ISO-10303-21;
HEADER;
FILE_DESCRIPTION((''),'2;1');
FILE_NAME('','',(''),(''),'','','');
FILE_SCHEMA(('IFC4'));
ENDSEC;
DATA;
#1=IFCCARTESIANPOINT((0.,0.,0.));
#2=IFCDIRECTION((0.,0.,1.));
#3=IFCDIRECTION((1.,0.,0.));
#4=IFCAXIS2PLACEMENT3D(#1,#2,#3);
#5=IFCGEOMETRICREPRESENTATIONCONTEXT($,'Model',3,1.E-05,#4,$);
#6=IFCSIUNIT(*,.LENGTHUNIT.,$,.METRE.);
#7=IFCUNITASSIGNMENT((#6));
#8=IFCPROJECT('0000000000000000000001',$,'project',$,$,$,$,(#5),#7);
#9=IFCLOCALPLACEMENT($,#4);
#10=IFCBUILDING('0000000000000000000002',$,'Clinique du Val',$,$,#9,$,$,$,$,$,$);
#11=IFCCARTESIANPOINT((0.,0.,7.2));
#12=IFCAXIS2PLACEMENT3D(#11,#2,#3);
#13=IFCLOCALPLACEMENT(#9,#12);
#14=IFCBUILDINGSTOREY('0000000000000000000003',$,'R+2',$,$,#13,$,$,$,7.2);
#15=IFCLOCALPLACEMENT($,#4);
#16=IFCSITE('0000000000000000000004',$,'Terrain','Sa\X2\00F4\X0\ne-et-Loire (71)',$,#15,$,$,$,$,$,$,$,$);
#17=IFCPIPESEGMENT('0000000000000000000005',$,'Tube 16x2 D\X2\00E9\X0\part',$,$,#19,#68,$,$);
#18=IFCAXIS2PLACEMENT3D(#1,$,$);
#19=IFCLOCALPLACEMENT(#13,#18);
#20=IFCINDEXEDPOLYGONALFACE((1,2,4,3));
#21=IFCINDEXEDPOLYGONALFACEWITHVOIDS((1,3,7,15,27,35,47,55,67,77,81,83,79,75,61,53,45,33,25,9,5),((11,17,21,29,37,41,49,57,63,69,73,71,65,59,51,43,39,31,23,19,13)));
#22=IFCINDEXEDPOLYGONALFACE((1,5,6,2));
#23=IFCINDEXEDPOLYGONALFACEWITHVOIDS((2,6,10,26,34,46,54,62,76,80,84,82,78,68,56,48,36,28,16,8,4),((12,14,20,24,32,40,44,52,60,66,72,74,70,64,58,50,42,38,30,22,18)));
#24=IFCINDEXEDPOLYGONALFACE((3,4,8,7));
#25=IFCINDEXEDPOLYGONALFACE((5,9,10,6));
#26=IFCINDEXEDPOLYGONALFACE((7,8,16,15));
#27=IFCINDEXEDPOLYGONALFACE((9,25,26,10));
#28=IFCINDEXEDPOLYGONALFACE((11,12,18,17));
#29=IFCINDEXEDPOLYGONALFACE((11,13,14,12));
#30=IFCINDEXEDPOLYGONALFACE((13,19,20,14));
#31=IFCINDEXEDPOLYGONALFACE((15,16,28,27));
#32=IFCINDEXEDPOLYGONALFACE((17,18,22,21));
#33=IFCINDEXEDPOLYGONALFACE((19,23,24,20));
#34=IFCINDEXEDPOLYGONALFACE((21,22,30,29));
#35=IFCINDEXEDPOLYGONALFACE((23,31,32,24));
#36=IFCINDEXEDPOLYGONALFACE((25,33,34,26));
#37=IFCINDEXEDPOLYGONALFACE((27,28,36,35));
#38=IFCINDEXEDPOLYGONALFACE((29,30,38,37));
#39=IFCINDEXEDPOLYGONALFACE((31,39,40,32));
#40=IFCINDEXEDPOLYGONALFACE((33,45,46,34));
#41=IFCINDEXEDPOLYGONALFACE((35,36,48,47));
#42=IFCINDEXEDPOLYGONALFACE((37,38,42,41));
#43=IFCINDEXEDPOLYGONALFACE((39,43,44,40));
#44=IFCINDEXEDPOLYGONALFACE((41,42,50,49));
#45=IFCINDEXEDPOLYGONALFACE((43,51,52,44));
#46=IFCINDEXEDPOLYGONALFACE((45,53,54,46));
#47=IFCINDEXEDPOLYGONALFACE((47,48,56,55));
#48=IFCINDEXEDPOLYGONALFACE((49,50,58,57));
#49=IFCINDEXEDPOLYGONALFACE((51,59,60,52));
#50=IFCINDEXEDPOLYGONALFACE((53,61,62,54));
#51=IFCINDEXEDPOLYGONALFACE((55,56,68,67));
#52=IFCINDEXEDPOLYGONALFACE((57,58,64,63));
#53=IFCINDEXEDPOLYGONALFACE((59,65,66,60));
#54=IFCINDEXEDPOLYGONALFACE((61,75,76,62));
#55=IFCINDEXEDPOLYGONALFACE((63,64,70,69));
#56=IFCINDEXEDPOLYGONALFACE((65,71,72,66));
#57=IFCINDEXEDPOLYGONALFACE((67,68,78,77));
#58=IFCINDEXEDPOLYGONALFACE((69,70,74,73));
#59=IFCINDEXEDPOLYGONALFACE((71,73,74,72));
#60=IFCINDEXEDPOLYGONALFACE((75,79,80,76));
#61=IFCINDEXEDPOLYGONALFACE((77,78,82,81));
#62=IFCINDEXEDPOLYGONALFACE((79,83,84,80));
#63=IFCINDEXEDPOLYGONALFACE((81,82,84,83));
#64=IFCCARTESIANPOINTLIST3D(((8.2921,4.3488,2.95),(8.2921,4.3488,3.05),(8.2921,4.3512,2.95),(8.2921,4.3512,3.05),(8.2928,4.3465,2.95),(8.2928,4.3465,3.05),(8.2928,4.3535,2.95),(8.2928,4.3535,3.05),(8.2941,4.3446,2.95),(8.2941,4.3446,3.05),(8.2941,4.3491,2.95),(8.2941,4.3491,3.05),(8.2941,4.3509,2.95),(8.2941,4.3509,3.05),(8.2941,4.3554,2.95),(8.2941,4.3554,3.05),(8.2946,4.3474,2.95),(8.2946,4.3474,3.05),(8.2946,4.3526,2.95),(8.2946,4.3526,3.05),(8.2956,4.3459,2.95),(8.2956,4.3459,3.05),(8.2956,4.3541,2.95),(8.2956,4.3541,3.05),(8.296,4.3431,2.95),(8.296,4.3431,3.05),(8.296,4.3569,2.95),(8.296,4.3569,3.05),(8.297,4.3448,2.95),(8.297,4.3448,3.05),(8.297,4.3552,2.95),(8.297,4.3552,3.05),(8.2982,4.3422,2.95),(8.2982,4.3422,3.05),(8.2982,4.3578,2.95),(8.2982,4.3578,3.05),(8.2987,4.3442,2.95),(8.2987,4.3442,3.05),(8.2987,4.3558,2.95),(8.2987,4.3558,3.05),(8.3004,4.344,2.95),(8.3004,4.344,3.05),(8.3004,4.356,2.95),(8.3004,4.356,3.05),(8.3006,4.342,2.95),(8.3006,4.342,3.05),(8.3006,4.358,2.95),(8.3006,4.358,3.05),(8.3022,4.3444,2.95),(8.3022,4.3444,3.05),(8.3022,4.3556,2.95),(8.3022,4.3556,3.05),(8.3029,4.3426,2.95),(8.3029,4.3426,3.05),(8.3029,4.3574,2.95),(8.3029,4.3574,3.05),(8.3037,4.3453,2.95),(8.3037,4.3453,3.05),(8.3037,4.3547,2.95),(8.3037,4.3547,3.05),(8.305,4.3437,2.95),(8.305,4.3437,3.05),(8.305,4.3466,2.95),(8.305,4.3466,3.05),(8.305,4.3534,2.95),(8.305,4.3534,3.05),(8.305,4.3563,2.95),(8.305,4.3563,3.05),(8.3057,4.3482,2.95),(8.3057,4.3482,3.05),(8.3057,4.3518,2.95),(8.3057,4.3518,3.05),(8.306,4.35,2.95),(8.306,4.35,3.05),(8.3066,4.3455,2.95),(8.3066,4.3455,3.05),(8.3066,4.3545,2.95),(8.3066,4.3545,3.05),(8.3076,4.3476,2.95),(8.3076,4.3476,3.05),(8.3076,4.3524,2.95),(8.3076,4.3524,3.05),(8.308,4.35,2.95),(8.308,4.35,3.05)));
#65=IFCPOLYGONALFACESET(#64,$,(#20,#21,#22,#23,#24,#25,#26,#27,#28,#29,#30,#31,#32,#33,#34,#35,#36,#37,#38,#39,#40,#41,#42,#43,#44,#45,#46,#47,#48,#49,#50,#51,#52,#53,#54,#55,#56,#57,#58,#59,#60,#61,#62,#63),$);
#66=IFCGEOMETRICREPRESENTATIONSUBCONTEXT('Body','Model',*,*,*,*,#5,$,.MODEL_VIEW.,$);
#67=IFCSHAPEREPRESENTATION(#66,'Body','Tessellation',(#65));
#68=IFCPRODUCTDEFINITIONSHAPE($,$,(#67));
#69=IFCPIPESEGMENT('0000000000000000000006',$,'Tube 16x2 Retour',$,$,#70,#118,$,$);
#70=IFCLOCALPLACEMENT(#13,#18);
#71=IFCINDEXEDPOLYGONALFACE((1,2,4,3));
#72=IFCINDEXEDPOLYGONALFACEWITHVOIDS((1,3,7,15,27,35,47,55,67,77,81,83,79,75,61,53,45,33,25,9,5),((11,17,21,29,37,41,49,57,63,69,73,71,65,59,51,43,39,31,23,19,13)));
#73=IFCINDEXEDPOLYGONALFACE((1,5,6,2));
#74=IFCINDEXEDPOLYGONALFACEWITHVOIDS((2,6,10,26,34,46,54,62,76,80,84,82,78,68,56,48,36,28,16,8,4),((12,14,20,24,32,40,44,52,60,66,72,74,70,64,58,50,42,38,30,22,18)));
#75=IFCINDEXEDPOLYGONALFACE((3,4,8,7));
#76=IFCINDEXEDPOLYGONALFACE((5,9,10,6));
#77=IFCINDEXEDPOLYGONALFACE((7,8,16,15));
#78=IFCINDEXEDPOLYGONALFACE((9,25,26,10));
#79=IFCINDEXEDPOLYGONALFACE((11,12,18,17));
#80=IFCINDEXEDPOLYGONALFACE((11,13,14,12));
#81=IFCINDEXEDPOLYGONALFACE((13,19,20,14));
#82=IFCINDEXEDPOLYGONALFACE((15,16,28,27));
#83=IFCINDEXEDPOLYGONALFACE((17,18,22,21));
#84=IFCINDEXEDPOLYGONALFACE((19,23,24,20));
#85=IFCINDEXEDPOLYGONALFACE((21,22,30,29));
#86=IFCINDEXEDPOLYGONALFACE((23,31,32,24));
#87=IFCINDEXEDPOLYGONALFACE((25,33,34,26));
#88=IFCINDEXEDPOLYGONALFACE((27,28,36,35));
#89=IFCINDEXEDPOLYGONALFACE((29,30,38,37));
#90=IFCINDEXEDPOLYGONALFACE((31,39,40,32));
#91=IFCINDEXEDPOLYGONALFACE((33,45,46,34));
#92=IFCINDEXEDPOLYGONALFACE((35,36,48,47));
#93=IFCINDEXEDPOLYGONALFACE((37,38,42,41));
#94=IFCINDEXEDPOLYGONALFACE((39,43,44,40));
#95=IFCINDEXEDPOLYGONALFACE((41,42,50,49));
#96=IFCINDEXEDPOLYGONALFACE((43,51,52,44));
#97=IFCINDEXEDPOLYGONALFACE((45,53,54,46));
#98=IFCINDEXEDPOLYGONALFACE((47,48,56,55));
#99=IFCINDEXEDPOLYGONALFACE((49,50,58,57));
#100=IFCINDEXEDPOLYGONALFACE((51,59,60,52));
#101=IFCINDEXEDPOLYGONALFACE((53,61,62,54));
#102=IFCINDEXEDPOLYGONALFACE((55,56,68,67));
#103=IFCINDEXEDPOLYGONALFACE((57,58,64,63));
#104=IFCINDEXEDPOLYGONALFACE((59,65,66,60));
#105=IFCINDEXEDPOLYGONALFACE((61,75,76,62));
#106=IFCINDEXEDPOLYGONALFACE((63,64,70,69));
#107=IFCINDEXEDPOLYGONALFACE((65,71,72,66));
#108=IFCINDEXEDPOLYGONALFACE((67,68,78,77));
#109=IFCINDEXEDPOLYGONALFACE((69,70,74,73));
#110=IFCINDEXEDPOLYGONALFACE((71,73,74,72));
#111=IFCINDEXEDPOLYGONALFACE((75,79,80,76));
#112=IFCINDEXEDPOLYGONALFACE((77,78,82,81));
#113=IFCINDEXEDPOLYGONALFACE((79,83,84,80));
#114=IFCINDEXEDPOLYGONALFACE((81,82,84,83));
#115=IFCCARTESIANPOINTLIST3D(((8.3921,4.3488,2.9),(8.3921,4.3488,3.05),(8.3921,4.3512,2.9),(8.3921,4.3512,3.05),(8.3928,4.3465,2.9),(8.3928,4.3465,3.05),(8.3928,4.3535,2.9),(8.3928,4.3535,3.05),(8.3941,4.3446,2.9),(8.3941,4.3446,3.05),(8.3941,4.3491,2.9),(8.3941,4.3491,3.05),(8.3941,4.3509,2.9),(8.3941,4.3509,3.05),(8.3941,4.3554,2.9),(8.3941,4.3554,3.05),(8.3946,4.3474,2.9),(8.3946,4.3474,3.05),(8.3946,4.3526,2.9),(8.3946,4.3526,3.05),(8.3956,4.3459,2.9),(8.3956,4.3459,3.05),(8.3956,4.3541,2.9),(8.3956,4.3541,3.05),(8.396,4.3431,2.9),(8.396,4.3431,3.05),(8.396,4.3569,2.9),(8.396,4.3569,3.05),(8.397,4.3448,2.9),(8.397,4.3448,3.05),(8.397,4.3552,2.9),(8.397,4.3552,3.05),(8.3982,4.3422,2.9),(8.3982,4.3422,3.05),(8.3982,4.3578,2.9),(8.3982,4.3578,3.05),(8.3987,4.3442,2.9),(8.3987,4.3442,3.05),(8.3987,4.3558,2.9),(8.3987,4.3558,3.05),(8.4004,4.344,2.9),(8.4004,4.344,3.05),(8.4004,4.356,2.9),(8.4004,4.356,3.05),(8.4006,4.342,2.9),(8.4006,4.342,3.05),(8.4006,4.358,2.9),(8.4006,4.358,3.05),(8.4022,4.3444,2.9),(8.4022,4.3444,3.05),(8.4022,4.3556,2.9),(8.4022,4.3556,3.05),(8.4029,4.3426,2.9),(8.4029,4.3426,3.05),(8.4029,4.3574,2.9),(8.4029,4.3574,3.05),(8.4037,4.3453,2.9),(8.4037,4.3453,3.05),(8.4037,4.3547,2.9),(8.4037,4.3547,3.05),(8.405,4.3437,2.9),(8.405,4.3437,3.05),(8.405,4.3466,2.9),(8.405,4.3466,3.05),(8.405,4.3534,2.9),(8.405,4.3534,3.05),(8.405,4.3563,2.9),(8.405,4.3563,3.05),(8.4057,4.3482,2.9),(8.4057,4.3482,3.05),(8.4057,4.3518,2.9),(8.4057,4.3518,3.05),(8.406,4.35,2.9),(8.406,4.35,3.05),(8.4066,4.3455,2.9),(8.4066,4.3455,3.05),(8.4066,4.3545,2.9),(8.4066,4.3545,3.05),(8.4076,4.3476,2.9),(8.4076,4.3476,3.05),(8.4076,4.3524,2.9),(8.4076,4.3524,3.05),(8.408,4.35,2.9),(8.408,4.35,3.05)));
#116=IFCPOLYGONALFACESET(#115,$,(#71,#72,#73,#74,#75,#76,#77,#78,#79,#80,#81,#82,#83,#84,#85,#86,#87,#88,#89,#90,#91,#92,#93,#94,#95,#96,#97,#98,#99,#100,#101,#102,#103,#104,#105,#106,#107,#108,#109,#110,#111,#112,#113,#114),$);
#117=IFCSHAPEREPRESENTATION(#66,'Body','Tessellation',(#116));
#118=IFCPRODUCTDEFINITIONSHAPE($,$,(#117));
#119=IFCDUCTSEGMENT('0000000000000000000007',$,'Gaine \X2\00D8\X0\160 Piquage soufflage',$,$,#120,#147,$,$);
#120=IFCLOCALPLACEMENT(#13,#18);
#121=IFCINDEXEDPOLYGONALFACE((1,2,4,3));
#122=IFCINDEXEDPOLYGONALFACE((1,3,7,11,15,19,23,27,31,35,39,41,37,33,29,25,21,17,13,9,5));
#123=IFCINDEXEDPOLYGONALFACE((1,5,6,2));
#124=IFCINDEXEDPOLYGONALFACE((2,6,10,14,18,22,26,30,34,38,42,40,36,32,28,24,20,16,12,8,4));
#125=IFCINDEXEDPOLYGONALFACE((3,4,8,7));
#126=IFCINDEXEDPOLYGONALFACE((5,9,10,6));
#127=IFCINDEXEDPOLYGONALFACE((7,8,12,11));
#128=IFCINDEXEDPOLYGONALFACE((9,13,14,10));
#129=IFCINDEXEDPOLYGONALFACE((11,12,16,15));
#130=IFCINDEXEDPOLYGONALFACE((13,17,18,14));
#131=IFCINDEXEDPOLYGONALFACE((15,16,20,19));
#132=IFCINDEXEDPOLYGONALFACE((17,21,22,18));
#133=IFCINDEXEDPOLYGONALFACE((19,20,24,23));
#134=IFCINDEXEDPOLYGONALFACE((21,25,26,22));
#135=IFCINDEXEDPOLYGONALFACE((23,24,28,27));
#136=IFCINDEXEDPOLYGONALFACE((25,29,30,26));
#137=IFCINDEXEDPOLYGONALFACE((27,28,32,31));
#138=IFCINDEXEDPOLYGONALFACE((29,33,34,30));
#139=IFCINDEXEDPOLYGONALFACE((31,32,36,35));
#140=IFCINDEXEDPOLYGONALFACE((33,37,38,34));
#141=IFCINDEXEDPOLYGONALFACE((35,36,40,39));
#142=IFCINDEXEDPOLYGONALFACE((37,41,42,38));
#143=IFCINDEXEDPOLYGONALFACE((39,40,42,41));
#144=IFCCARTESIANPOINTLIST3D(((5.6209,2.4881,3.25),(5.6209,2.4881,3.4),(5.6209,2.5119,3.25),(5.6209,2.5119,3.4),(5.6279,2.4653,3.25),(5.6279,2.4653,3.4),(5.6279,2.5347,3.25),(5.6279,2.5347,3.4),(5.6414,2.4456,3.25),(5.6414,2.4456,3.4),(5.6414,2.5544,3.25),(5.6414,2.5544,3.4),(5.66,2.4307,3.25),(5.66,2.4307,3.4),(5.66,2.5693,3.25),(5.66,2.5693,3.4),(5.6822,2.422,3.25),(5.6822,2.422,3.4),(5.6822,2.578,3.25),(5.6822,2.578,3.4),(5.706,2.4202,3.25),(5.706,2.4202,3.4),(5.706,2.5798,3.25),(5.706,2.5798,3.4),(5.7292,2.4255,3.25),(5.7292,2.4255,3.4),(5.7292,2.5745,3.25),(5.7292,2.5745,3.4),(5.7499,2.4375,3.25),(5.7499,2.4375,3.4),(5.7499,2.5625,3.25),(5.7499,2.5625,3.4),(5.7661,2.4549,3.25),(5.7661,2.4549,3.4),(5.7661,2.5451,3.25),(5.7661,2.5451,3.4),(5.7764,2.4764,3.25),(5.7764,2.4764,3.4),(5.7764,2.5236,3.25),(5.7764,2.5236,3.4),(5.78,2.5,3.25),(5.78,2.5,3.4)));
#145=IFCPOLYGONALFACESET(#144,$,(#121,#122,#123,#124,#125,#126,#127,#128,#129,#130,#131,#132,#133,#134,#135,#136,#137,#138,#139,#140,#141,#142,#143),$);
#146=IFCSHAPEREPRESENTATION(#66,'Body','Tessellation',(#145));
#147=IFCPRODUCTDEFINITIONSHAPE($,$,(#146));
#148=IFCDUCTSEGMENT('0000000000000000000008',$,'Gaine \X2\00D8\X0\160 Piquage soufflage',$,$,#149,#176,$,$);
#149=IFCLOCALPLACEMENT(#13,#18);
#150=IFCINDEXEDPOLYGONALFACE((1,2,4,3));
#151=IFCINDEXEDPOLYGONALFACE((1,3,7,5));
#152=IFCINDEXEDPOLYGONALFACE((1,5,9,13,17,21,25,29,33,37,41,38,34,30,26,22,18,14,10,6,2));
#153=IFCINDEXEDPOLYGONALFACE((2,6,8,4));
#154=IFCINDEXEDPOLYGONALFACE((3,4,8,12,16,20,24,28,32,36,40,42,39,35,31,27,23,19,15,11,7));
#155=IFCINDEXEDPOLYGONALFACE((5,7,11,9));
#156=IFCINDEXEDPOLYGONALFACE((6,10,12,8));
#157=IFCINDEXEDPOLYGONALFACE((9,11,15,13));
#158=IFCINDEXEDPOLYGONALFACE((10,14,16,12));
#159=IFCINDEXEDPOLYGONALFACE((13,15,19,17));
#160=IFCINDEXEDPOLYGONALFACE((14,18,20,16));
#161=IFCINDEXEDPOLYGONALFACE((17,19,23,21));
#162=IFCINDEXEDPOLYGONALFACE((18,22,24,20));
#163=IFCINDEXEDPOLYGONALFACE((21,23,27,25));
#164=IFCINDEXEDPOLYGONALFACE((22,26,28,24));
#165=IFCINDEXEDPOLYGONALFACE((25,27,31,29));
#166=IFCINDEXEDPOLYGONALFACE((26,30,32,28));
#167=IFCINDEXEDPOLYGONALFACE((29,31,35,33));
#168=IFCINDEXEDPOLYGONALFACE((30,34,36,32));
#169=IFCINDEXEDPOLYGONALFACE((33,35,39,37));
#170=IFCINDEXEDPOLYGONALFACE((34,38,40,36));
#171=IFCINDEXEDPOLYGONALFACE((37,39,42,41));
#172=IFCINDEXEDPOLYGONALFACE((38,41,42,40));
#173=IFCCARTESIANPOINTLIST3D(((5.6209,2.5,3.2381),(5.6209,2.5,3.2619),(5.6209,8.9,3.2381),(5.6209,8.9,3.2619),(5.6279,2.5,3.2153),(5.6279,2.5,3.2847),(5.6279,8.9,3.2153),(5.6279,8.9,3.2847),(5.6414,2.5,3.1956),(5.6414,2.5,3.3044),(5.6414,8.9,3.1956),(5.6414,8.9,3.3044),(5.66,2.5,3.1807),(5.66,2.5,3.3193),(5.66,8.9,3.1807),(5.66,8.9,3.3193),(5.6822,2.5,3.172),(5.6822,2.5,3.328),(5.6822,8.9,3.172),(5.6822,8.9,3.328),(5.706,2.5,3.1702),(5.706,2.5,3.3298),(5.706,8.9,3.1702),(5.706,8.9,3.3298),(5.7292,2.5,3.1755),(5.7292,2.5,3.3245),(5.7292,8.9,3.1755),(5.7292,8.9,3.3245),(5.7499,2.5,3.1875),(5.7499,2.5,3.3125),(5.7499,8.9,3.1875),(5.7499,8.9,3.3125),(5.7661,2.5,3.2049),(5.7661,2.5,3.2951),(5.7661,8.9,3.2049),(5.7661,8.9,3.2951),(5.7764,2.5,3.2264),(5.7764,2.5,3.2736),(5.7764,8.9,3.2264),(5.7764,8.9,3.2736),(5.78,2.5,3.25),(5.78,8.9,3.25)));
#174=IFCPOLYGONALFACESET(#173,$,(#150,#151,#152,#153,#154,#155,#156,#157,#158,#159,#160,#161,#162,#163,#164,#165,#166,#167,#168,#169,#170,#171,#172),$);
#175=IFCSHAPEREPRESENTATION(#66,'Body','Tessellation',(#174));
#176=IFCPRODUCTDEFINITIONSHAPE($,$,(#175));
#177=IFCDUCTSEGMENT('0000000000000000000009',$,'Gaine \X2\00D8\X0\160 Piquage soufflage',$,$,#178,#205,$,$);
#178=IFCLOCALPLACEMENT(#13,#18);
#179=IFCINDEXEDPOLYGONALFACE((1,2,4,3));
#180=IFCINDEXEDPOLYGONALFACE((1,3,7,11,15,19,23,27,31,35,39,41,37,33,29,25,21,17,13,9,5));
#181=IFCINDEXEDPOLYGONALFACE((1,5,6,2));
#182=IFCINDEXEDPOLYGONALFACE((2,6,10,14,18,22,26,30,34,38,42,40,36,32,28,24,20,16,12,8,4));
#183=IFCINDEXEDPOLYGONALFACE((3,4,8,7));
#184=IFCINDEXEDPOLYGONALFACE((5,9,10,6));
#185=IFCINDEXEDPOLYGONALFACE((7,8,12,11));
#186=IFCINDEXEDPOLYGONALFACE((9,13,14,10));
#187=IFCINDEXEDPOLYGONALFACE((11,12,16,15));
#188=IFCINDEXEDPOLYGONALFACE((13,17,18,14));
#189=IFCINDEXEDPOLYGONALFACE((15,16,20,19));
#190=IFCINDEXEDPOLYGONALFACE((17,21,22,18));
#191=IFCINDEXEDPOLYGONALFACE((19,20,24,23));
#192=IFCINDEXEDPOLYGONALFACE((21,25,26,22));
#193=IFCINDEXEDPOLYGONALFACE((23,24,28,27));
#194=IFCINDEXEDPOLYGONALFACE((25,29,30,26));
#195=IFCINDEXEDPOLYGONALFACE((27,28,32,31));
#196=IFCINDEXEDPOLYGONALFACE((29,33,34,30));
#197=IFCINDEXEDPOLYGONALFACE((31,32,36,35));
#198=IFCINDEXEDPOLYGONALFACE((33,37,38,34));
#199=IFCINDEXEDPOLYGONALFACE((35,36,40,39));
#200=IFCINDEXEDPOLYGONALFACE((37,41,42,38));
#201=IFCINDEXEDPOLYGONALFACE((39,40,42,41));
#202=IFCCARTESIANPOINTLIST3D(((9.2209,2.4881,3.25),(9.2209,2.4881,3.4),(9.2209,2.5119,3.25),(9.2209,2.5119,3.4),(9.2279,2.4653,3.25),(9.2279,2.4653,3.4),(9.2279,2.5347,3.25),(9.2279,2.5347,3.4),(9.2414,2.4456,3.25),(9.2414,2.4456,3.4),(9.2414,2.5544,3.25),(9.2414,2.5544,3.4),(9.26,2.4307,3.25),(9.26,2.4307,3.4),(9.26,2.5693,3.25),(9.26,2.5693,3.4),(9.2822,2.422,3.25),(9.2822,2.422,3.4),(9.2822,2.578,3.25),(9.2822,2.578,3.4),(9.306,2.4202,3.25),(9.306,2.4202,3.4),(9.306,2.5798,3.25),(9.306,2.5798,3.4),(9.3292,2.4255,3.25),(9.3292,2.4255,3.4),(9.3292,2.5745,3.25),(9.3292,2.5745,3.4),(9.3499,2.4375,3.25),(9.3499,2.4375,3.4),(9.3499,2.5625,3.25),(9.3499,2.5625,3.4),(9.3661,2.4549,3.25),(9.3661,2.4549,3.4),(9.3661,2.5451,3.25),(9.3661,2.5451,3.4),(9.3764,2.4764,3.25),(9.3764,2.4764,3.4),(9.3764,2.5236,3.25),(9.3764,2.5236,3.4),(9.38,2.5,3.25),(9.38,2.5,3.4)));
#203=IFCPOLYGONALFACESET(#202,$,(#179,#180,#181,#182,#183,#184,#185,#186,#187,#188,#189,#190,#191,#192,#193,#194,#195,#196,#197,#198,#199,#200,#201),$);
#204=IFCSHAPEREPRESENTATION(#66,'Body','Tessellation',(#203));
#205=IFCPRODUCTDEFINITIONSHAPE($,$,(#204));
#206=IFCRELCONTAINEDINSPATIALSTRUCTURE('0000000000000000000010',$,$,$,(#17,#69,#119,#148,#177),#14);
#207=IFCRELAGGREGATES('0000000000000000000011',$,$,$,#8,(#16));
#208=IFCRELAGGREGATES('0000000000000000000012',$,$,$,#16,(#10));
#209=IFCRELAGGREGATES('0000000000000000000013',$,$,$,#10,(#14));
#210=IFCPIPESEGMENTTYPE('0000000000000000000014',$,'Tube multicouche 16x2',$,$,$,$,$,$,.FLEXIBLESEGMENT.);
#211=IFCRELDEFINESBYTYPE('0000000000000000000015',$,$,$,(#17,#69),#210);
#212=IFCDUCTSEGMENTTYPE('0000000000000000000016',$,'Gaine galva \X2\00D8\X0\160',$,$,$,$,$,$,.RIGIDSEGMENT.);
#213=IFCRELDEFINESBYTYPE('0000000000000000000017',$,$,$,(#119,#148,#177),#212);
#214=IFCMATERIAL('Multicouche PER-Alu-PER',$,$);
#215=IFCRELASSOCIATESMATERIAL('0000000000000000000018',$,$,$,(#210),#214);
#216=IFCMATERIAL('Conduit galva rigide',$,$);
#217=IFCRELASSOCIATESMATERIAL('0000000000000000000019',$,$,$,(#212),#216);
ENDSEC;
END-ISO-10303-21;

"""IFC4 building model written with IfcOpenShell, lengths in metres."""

from ifc_helpers import new_model, si_unit, frame, origin_with_axes, place, context, subcontext, project, spatial, circle, hollow_circle, extrude, material, type_object, element, save


model = new_model("IFC4")

# Units and contexts
model_context = context("Model", 3, precision=1e-05, world=origin_with_axes())
body_context = subcontext(model_context, "Body", "Model", "MODEL_VIEW")
ifc_project = project(units=[si_unit("LENGTHUNIT", "METRE")], contexts=[model_context])

# Site, building, storey
site_placement = place(None, origin_with_axes())
site = spatial("IfcSite", under=ifc_project, at=site_placement, Name="Terrain", Description="Saône-et-Loire (71)")
building_placement = place(None, origin_with_axes())
building = spatial("IfcBuilding", under=site, at=building_placement, Name="Clinique du Val")
storey_placement = place(building_placement, frame((0.0, 0.0, 7.2), z_axis=(0.0, 0.0, 1.0), x_axis=(1.0, 0.0, 0.0)))
storey = spatial("IfcBuildingStorey", under=building, at=storey_placement, Name="R+2", Elevation=7.2)

# Pipe segments
ifc_material_1 = material(Name="Multicouche PER-Alu-PER")
pipe_segment_type = type_object("IfcPipeSegmentType", Name="Tube multicouche 16x2", PredefinedType="FLEXIBLESEGMENT", material=ifc_material_1)
pipe_segment_1_placement = place(storey_placement, frame((8.3, 4.35, 2.95), z_axis=(0.0, 0.0, 1.0), x_axis=(1.0, 0.0, 0.0)))
element("IfcPipeSegment", 1, at=pipe_segment_1_placement, inside=storey, type_object=pipe_segment_type, Name="Tube 16x2 Départ", context=body_context, shape_type="SweptSolid", body=[
    extrude(hollow_circle(Radius=0.008, WallThickness=0.002), origin_with_axes(), (0.0, 0.0, 1.0), 0.1),
])
pipe_segment_2_placement = place(storey_placement, frame((8.4, 4.35, 2.9), z_axis=(0.0, 0.0, 1.0), x_axis=(1.0, 0.0, 0.0)))
element("IfcPipeSegment", 2, at=pipe_segment_2_placement, inside=storey, type_object=pipe_segment_type, Name="Tube 16x2 Retour", context=body_context, shape_type="SweptSolid", body=[
    extrude(hollow_circle(Radius=0.008, WallThickness=0.002), origin_with_axes(), (0.0, 0.0, 1.0), 0.15),
])

# Duct segments
ifc_material_2 = material(Name="Conduit galva rigide")
duct_segment_type = type_object("IfcDuctSegmentType", Name="Gaine galva Ø160", PredefinedType="RIGIDSEGMENT", material=ifc_material_2)
duct_segment_1_placement = place(storey_placement, frame((5.7, 2.5, 3.4), z_axis=(0.0, 0.0, -1.0), x_axis=(1.0, 0.0, 0.0)))
element("IfcDuctSegment", 3, at=duct_segment_1_placement, inside=storey, type_object=duct_segment_type, Name="Gaine Ø160 Piquage soufflage", context=body_context, shape_type="SweptSolid", body=[
    extrude(circle(Radius=0.08), origin_with_axes(), (0.0, 0.0, 1.0), 0.15),
])
duct_segment_2_placement = place(storey_placement, frame((5.7, 2.5, 3.25), z_axis=(0.0, 1.0, 0.0), x_axis=(1.0, 0.0, 0.0)))
element("IfcDuctSegment", 4, at=duct_segment_2_placement, inside=storey, type_object=duct_segment_type, Name="Gaine Ø160 Piquage soufflage", context=body_context, shape_type="SweptSolid", body=[
    extrude(circle(Radius=0.08), origin_with_axes(), (0.0, 0.0, 1.0), 6.4),
])
duct_segment_3_placement = place(storey_placement, frame((9.3, 2.5, 3.4), z_axis=(0.0, 0.0, -1.0), x_axis=(1.0, 0.0, 0.0)))
element("IfcDuctSegment", 5, at=duct_segment_3_placement, inside=storey, type_object=duct_segment_type, Name="Gaine Ø160 Piquage soufflage", context=body_context, shape_type="SweptSolid", body=[
    extrude(circle(Radius=0.08), origin_with_axes(), (0.0, 0.0, 1.0), 0.15),
])

save(model, "model.ifc")
